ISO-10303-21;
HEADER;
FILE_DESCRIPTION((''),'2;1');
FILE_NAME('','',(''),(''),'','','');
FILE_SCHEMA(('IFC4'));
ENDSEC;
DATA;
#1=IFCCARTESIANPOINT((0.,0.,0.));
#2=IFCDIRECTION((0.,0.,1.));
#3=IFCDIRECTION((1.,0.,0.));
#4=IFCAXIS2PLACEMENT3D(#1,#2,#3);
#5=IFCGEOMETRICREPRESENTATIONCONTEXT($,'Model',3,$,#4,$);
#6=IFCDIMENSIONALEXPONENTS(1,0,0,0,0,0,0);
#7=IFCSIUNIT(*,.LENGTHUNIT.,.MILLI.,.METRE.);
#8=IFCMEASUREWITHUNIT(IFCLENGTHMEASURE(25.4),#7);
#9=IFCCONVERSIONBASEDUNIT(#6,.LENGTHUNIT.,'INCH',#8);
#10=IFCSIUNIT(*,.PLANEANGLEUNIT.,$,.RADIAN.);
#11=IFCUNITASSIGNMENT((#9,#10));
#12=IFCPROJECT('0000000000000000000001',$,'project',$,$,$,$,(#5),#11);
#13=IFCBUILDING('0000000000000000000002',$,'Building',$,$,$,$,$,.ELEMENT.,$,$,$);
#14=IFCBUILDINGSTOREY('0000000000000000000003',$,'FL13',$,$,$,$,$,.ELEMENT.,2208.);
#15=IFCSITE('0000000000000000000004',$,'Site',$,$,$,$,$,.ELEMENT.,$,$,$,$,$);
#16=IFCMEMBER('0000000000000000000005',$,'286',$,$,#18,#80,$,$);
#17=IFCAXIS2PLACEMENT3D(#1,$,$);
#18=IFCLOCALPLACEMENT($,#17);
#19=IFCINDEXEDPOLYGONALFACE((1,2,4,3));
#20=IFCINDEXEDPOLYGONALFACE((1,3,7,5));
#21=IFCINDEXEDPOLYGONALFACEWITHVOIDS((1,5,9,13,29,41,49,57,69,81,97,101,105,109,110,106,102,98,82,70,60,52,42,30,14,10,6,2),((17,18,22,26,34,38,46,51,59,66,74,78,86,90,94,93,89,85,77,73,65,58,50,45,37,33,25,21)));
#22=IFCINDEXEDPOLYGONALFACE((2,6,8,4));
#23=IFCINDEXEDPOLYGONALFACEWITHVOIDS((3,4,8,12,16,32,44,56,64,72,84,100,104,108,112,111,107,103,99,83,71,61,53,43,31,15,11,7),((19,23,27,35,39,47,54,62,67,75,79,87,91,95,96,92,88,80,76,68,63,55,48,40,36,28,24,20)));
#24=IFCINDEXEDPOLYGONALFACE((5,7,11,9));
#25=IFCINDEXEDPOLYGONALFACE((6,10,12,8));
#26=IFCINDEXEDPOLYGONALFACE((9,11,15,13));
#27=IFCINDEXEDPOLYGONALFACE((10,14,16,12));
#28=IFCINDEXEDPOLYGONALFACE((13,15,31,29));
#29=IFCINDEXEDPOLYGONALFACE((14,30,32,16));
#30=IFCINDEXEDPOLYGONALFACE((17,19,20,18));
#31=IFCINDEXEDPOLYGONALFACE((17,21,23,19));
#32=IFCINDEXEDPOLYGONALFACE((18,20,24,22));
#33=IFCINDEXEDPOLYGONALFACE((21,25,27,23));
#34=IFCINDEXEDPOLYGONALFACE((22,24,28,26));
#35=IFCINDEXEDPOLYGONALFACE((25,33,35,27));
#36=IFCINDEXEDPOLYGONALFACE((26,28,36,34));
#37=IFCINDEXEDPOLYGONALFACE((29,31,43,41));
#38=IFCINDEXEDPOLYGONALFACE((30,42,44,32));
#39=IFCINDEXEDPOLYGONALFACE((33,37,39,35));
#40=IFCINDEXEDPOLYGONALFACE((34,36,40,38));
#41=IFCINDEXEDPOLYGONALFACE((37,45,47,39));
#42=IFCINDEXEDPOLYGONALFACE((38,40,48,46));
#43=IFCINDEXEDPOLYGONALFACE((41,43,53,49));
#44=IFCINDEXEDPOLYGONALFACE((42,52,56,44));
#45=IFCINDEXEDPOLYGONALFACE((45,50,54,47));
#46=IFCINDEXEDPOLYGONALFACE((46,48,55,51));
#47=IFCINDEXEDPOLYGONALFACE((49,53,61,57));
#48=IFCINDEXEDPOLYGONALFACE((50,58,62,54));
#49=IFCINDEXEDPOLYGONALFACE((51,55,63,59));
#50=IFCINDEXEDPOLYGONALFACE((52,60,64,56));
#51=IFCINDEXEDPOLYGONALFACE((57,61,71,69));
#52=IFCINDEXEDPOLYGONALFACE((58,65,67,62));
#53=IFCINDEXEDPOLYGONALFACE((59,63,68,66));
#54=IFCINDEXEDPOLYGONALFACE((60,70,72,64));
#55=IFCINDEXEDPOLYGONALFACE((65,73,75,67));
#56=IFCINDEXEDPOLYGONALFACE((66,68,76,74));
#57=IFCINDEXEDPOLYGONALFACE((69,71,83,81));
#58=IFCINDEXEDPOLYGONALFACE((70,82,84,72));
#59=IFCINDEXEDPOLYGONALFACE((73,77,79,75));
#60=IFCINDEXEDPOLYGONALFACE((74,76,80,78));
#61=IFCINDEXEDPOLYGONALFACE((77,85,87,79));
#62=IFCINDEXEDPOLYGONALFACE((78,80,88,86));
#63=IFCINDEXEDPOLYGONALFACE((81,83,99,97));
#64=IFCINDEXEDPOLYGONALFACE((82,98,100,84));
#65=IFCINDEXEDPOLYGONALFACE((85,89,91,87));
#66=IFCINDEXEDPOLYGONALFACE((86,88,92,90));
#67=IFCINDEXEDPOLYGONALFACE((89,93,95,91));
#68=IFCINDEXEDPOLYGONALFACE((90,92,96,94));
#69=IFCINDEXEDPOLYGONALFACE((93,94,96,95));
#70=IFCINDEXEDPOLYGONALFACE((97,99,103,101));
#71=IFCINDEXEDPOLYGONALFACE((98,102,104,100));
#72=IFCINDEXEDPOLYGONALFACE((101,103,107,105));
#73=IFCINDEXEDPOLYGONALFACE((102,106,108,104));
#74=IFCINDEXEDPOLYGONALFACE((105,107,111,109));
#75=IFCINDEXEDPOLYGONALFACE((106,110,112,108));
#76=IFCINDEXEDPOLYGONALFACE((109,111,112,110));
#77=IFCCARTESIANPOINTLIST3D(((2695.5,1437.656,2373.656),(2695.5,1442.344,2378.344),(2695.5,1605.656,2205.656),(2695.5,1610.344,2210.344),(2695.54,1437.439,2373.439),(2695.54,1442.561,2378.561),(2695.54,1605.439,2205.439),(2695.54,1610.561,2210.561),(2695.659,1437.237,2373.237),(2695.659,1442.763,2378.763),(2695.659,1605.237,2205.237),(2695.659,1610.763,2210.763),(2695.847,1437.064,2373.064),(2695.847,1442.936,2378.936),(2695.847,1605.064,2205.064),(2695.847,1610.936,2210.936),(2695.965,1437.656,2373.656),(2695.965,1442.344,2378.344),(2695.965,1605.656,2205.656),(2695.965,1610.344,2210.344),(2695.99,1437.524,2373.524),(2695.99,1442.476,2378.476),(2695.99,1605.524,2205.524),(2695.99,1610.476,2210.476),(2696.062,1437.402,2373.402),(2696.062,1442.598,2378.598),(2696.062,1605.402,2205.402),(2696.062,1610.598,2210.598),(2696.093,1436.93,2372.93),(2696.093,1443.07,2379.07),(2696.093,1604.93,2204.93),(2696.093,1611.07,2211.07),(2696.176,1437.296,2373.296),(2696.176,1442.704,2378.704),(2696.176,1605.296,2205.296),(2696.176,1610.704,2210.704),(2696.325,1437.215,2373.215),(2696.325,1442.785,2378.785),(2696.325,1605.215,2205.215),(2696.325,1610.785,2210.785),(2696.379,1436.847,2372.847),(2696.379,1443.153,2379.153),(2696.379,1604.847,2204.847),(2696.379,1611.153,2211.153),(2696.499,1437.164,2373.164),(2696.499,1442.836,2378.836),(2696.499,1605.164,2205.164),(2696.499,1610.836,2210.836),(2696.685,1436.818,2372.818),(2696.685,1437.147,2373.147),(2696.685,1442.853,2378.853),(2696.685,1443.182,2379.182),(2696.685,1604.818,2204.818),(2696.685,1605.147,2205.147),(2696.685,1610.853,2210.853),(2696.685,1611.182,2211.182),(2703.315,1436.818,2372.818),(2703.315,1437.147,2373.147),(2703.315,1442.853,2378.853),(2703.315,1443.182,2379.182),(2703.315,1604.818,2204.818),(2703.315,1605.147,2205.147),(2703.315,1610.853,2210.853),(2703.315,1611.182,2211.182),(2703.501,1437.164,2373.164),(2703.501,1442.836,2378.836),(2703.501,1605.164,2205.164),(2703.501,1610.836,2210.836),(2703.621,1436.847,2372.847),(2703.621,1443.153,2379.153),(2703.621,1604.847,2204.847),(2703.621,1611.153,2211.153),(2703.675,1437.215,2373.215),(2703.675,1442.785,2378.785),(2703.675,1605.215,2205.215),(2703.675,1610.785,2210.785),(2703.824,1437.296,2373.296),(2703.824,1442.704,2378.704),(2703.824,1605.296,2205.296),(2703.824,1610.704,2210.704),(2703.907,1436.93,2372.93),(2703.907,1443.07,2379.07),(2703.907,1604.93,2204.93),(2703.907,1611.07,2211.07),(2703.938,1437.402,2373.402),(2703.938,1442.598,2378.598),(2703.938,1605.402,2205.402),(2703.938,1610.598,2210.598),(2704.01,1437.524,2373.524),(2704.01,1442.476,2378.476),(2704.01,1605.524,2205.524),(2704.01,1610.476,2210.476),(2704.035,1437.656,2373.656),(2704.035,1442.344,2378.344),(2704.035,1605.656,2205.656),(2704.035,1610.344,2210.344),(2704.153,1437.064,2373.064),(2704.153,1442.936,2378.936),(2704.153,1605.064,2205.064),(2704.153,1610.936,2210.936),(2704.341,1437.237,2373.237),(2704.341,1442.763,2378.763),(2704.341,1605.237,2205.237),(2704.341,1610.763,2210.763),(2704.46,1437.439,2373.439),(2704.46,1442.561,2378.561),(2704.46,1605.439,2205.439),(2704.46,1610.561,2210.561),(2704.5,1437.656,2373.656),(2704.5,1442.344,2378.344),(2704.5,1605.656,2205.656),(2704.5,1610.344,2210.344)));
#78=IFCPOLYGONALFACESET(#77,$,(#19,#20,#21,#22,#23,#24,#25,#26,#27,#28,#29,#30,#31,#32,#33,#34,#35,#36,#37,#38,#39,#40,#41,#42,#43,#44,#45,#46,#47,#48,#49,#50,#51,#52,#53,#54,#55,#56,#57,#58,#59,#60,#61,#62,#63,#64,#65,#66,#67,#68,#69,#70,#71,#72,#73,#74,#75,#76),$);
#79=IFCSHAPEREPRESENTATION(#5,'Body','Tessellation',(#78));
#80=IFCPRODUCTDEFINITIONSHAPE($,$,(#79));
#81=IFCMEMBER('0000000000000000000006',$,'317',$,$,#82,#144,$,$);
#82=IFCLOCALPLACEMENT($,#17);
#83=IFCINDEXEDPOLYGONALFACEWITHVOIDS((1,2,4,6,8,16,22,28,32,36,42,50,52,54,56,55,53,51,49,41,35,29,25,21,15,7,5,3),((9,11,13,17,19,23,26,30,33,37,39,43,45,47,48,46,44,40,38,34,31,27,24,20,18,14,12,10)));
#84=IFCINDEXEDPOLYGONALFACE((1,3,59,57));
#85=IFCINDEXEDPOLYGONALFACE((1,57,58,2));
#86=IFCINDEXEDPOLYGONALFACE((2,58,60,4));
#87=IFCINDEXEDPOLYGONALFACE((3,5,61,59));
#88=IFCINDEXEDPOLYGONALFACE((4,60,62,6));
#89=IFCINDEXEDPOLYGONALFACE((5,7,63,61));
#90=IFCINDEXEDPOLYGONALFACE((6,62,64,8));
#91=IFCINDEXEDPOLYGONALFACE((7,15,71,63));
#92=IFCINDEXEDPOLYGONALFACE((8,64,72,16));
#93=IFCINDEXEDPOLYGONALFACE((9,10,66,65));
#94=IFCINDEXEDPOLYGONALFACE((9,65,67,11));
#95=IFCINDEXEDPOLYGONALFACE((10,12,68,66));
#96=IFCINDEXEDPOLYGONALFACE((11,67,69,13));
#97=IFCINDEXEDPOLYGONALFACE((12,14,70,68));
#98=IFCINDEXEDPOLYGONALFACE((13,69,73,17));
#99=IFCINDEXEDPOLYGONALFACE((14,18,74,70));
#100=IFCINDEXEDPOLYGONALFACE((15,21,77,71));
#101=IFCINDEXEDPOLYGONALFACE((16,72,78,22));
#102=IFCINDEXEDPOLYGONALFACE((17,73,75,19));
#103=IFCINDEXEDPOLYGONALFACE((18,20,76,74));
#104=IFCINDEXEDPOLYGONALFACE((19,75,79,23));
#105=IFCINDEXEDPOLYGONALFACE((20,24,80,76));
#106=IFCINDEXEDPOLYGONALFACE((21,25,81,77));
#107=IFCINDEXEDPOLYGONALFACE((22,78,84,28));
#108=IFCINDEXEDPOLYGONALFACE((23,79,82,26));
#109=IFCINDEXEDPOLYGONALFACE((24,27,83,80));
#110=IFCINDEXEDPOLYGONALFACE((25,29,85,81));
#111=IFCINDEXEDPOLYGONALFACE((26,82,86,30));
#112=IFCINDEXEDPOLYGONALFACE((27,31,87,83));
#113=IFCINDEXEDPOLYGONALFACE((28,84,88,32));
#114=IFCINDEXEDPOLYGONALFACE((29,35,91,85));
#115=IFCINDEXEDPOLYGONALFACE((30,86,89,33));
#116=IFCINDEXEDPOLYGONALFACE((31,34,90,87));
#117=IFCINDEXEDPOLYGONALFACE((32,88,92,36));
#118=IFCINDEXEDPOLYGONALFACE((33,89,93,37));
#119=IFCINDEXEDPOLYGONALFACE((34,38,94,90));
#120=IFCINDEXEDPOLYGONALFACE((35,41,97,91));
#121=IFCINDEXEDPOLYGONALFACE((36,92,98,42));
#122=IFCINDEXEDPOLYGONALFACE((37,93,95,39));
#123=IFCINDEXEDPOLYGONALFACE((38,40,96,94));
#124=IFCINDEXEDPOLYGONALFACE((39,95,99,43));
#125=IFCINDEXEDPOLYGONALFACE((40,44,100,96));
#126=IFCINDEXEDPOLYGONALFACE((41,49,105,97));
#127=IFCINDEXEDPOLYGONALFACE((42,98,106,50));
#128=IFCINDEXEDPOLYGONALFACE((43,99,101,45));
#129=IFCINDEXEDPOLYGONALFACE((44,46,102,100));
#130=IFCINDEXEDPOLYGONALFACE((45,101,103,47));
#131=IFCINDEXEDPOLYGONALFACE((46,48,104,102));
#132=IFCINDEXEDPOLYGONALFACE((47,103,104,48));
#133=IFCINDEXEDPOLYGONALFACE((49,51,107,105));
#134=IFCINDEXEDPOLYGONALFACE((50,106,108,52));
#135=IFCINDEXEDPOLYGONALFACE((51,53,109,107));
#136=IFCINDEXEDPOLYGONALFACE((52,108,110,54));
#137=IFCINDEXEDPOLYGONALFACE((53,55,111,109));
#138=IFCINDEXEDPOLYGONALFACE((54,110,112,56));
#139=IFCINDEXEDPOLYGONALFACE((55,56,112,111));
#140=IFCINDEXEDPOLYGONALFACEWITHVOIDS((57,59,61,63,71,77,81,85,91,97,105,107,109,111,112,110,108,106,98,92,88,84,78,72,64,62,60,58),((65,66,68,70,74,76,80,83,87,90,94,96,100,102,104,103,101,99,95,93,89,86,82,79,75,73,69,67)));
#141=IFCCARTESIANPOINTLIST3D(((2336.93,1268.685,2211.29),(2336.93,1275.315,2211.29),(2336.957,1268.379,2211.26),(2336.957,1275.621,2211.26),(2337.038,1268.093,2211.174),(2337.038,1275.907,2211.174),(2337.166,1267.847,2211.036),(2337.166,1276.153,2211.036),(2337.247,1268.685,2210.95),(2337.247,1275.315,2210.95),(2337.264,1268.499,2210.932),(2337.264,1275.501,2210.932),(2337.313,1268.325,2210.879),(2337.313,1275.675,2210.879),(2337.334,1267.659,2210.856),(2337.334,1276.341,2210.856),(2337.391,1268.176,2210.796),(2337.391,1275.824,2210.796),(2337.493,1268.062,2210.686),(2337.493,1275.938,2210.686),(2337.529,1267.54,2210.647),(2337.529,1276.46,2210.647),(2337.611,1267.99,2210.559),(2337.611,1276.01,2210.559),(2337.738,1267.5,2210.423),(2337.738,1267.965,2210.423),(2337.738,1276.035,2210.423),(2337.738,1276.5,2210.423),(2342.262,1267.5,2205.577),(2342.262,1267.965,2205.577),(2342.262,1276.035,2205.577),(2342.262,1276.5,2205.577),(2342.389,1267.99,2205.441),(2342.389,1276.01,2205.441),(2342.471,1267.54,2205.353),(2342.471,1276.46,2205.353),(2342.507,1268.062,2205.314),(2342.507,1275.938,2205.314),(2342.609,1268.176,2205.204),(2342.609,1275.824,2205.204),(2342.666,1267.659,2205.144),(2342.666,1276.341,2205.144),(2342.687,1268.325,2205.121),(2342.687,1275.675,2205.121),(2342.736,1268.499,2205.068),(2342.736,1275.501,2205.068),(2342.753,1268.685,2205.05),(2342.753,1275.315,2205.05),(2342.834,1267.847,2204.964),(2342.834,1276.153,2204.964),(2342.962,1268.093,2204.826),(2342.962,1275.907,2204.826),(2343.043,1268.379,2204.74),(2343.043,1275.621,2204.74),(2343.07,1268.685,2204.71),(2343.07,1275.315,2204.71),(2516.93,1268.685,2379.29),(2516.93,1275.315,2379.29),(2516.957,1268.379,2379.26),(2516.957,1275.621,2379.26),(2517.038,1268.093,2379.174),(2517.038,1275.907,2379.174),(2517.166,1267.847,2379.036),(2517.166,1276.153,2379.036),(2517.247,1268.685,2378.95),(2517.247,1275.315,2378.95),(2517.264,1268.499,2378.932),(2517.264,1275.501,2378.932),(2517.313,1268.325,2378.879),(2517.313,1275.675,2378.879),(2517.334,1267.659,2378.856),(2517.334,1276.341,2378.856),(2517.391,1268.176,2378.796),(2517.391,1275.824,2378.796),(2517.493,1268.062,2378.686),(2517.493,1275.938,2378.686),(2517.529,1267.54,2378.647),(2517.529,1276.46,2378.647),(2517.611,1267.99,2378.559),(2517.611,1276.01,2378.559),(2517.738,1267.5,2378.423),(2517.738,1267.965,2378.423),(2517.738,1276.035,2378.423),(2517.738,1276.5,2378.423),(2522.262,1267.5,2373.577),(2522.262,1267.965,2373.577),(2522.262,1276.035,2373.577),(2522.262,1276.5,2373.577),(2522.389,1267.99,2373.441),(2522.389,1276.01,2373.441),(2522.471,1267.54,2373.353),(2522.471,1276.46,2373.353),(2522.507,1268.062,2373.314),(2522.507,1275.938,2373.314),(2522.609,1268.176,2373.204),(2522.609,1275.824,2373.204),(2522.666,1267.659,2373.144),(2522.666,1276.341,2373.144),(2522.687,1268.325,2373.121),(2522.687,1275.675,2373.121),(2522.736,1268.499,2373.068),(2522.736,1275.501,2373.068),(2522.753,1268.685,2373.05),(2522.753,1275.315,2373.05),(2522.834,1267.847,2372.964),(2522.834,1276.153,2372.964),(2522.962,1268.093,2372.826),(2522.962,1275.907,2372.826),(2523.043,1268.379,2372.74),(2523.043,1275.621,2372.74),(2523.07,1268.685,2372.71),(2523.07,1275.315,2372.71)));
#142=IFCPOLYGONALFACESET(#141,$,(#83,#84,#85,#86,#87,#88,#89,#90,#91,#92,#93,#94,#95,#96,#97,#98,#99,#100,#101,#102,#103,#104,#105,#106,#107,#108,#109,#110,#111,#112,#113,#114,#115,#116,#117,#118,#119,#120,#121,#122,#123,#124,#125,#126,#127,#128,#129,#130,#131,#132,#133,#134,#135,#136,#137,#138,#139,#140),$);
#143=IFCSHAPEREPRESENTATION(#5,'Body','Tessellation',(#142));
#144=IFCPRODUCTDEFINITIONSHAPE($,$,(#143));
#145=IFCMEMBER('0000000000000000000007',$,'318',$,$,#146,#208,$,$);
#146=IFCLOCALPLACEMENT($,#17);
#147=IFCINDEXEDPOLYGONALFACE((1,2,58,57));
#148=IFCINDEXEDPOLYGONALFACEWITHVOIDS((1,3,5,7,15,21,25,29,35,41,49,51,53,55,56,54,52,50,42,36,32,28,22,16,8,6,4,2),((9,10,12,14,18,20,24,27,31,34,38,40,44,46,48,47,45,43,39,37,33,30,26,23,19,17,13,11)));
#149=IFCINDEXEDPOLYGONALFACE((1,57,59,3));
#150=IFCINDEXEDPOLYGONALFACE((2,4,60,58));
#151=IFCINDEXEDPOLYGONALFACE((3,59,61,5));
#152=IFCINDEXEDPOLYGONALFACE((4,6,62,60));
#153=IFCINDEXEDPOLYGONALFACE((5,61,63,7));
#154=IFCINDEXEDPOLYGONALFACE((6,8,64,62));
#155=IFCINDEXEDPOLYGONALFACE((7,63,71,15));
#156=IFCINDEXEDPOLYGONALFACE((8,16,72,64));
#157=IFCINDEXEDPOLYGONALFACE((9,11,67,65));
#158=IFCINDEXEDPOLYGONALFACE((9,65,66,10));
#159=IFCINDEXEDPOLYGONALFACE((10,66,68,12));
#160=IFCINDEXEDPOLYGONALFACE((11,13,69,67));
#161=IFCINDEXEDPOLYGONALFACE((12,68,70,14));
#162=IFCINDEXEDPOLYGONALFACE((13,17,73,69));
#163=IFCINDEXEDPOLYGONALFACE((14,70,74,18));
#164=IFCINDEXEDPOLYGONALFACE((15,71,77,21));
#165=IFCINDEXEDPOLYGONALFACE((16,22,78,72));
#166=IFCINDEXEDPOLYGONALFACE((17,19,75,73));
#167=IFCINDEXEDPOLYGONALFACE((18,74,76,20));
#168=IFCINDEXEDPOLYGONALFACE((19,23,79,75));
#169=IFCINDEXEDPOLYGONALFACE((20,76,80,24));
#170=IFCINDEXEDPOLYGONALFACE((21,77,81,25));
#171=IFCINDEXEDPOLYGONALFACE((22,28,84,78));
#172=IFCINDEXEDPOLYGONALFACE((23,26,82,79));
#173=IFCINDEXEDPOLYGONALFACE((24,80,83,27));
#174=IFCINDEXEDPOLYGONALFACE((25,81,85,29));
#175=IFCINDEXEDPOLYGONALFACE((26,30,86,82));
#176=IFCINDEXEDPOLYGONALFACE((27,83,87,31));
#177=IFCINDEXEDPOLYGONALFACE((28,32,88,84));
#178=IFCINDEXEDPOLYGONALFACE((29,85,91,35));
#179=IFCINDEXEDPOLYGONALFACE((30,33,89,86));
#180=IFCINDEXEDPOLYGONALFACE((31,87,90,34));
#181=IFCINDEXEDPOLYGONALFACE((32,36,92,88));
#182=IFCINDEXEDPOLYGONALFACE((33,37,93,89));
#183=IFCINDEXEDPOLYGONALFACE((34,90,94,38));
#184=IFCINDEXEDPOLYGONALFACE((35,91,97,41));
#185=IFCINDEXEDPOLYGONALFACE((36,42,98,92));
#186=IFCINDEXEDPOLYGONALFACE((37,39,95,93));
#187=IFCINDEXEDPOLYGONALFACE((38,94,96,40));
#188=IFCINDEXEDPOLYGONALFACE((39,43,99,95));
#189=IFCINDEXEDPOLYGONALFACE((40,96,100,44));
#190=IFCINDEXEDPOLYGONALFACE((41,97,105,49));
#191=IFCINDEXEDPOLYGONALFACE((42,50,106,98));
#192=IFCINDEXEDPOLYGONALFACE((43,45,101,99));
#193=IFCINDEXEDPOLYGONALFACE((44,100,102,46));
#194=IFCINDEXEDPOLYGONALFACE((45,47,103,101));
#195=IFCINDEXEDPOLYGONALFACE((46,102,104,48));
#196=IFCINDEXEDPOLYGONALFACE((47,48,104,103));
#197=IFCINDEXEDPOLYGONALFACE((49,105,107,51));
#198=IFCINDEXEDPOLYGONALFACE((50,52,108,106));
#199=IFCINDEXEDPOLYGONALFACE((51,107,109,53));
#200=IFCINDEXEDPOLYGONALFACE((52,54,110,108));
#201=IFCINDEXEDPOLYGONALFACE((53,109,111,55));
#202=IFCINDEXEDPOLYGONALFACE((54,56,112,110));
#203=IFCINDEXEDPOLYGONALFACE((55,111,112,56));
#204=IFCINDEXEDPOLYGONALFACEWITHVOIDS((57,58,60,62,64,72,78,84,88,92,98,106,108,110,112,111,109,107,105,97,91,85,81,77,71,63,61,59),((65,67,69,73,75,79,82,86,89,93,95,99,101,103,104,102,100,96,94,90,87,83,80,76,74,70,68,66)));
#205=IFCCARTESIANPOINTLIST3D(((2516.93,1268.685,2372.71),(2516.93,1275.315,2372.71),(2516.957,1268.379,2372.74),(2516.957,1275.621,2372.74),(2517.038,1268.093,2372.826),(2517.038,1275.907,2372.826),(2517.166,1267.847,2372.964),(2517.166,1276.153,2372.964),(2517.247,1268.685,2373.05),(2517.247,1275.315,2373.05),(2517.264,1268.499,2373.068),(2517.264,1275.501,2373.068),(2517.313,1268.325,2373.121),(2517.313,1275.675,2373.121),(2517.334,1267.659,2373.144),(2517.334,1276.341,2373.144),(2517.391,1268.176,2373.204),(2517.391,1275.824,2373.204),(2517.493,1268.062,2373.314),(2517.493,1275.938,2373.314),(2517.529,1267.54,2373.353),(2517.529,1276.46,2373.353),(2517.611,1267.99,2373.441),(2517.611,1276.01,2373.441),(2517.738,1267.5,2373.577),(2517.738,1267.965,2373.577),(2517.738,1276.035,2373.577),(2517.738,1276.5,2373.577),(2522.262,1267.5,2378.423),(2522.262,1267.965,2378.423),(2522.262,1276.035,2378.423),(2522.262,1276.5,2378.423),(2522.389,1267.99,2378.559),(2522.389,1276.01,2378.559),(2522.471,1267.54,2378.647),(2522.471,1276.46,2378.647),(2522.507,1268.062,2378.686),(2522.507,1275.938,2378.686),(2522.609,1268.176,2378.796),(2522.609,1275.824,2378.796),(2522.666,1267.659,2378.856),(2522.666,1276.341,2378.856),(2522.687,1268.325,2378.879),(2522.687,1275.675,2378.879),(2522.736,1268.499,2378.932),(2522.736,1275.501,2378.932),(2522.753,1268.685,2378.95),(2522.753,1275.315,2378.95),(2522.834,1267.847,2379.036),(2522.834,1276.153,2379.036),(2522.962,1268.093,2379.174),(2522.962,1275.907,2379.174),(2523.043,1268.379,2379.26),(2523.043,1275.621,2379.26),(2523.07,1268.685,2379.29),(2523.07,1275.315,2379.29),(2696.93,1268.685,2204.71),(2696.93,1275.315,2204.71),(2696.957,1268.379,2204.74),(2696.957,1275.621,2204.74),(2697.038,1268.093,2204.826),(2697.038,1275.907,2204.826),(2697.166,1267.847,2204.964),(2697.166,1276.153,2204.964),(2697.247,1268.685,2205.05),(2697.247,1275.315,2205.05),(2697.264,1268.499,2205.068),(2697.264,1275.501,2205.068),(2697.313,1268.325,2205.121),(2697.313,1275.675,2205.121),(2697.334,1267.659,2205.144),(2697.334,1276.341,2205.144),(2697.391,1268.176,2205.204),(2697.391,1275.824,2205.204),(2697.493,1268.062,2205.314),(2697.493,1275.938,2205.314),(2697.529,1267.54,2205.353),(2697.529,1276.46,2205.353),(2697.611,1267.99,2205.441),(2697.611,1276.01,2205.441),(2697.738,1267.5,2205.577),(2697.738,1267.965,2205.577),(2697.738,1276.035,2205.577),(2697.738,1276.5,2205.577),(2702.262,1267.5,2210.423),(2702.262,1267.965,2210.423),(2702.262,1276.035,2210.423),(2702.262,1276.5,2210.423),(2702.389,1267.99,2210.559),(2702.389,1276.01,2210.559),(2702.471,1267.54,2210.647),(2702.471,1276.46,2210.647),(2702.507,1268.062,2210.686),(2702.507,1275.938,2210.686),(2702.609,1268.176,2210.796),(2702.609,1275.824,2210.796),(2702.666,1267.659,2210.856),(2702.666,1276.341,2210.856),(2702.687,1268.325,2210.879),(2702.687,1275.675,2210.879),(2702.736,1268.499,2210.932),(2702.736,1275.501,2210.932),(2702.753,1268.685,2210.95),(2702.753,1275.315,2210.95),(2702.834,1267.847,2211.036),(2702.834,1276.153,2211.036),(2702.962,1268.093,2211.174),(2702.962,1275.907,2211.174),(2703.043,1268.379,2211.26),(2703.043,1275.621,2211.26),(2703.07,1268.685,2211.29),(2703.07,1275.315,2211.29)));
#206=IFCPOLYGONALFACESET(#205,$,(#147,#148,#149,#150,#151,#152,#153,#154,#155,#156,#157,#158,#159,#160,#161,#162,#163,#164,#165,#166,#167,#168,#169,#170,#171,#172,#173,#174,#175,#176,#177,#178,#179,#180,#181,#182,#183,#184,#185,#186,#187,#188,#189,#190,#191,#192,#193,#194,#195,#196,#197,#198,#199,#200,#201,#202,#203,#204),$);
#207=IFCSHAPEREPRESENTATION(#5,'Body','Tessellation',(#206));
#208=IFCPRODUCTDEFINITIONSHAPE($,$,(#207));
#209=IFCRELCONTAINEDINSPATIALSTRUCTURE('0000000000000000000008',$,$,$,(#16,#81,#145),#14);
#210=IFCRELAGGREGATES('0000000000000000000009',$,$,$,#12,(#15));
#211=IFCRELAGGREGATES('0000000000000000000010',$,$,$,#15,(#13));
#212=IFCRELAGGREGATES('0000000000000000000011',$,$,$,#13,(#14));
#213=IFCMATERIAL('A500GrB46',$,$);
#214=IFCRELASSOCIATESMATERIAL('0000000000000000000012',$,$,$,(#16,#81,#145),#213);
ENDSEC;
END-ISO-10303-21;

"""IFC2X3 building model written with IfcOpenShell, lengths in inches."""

from ifc_helpers import new_model, entity, si_unit, converted_unit, frame, origin_with_axes, origin_2d_with_axis, place, context, project, spatial, hollow_rectangle, extrude, material, element, save


model = new_model("IFC2X3")

# Units and contexts
model_context = context("Model", 3, world=origin_with_axes())
ifc_project = project(units=[converted_unit("LENGTHUNIT", "INCH", entity("IfcLengthMeasure", 25.4), si_unit("LENGTHUNIT", "METRE", prefix="MILLI"), dimensions=[1, 0, 0, 0, 0, 0, 0]), si_unit("PLANEANGLEUNIT", "RADIAN")], contexts=[model_context])

# Site, building, storey
site = spatial("IfcSite", under=ifc_project, Name="Site", CompositionType="ELEMENT")
building = spatial("IfcBuilding", under=site, Name="Building", CompositionType="ELEMENT")
storey = spatial("IfcBuildingStorey", under=building, Name="FL13", CompositionType="ELEMENT", Elevation=2208.0)

# Members
ifc_material_1 = material(Name="A500GrB46")
for number, where, z_axis, x_axis, name in (
    (1, (2700.0, 1608.0, 2208.0), (0.0, -0.707107, 0.707107), (1.0, 0.0, 0.0), "286"),
):
    element("IfcMember", number, at=place(None, frame(where, z_axis=z_axis, x_axis=x_axis)), inside=storey, material=ifc_material_1, Name=name, context=model_context, shape_type="SweptSolid", body=[
        extrude(hollow_rectangle(XDim=9.0, YDim=9.0, WallThickness=0.465, InnerFilletRadius=0.72, OuterFilletRadius=1.185, at=origin_2d_with_axis()), origin_with_axes(), (0.0, 0.0, 1.0), 237.588),
    ])
for number, where, z_axis, x_axis, name in (
    (2, (2340.0, 1272.0, 2208.0), (0.731055, 0.0, 0.682318), (0.0, 1.0, 0.0), "317"),
    (3, (2700.0, 1272.0, 2208.0), (-0.731055, 0.0, 0.682318), (0.0, -1.0, 0.0), "318"),
):
    element("IfcMember", number, at=place(None, frame(where, z_axis=z_axis, x_axis=x_axis)), inside=storey, material=ifc_material_1, Name=name, context=model_context, shape_type="SweptSolid", body=[
        extrude(hollow_rectangle(XDim=9.0, YDim=9.0, WallThickness=0.465, InnerFilletRadius=0.72, OuterFilletRadius=1.185, at=origin_2d_with_axis()), origin_with_axes(), (0.0, 0.0, 1.0), 246.219),
    ])

save(model, "model.ifc")
